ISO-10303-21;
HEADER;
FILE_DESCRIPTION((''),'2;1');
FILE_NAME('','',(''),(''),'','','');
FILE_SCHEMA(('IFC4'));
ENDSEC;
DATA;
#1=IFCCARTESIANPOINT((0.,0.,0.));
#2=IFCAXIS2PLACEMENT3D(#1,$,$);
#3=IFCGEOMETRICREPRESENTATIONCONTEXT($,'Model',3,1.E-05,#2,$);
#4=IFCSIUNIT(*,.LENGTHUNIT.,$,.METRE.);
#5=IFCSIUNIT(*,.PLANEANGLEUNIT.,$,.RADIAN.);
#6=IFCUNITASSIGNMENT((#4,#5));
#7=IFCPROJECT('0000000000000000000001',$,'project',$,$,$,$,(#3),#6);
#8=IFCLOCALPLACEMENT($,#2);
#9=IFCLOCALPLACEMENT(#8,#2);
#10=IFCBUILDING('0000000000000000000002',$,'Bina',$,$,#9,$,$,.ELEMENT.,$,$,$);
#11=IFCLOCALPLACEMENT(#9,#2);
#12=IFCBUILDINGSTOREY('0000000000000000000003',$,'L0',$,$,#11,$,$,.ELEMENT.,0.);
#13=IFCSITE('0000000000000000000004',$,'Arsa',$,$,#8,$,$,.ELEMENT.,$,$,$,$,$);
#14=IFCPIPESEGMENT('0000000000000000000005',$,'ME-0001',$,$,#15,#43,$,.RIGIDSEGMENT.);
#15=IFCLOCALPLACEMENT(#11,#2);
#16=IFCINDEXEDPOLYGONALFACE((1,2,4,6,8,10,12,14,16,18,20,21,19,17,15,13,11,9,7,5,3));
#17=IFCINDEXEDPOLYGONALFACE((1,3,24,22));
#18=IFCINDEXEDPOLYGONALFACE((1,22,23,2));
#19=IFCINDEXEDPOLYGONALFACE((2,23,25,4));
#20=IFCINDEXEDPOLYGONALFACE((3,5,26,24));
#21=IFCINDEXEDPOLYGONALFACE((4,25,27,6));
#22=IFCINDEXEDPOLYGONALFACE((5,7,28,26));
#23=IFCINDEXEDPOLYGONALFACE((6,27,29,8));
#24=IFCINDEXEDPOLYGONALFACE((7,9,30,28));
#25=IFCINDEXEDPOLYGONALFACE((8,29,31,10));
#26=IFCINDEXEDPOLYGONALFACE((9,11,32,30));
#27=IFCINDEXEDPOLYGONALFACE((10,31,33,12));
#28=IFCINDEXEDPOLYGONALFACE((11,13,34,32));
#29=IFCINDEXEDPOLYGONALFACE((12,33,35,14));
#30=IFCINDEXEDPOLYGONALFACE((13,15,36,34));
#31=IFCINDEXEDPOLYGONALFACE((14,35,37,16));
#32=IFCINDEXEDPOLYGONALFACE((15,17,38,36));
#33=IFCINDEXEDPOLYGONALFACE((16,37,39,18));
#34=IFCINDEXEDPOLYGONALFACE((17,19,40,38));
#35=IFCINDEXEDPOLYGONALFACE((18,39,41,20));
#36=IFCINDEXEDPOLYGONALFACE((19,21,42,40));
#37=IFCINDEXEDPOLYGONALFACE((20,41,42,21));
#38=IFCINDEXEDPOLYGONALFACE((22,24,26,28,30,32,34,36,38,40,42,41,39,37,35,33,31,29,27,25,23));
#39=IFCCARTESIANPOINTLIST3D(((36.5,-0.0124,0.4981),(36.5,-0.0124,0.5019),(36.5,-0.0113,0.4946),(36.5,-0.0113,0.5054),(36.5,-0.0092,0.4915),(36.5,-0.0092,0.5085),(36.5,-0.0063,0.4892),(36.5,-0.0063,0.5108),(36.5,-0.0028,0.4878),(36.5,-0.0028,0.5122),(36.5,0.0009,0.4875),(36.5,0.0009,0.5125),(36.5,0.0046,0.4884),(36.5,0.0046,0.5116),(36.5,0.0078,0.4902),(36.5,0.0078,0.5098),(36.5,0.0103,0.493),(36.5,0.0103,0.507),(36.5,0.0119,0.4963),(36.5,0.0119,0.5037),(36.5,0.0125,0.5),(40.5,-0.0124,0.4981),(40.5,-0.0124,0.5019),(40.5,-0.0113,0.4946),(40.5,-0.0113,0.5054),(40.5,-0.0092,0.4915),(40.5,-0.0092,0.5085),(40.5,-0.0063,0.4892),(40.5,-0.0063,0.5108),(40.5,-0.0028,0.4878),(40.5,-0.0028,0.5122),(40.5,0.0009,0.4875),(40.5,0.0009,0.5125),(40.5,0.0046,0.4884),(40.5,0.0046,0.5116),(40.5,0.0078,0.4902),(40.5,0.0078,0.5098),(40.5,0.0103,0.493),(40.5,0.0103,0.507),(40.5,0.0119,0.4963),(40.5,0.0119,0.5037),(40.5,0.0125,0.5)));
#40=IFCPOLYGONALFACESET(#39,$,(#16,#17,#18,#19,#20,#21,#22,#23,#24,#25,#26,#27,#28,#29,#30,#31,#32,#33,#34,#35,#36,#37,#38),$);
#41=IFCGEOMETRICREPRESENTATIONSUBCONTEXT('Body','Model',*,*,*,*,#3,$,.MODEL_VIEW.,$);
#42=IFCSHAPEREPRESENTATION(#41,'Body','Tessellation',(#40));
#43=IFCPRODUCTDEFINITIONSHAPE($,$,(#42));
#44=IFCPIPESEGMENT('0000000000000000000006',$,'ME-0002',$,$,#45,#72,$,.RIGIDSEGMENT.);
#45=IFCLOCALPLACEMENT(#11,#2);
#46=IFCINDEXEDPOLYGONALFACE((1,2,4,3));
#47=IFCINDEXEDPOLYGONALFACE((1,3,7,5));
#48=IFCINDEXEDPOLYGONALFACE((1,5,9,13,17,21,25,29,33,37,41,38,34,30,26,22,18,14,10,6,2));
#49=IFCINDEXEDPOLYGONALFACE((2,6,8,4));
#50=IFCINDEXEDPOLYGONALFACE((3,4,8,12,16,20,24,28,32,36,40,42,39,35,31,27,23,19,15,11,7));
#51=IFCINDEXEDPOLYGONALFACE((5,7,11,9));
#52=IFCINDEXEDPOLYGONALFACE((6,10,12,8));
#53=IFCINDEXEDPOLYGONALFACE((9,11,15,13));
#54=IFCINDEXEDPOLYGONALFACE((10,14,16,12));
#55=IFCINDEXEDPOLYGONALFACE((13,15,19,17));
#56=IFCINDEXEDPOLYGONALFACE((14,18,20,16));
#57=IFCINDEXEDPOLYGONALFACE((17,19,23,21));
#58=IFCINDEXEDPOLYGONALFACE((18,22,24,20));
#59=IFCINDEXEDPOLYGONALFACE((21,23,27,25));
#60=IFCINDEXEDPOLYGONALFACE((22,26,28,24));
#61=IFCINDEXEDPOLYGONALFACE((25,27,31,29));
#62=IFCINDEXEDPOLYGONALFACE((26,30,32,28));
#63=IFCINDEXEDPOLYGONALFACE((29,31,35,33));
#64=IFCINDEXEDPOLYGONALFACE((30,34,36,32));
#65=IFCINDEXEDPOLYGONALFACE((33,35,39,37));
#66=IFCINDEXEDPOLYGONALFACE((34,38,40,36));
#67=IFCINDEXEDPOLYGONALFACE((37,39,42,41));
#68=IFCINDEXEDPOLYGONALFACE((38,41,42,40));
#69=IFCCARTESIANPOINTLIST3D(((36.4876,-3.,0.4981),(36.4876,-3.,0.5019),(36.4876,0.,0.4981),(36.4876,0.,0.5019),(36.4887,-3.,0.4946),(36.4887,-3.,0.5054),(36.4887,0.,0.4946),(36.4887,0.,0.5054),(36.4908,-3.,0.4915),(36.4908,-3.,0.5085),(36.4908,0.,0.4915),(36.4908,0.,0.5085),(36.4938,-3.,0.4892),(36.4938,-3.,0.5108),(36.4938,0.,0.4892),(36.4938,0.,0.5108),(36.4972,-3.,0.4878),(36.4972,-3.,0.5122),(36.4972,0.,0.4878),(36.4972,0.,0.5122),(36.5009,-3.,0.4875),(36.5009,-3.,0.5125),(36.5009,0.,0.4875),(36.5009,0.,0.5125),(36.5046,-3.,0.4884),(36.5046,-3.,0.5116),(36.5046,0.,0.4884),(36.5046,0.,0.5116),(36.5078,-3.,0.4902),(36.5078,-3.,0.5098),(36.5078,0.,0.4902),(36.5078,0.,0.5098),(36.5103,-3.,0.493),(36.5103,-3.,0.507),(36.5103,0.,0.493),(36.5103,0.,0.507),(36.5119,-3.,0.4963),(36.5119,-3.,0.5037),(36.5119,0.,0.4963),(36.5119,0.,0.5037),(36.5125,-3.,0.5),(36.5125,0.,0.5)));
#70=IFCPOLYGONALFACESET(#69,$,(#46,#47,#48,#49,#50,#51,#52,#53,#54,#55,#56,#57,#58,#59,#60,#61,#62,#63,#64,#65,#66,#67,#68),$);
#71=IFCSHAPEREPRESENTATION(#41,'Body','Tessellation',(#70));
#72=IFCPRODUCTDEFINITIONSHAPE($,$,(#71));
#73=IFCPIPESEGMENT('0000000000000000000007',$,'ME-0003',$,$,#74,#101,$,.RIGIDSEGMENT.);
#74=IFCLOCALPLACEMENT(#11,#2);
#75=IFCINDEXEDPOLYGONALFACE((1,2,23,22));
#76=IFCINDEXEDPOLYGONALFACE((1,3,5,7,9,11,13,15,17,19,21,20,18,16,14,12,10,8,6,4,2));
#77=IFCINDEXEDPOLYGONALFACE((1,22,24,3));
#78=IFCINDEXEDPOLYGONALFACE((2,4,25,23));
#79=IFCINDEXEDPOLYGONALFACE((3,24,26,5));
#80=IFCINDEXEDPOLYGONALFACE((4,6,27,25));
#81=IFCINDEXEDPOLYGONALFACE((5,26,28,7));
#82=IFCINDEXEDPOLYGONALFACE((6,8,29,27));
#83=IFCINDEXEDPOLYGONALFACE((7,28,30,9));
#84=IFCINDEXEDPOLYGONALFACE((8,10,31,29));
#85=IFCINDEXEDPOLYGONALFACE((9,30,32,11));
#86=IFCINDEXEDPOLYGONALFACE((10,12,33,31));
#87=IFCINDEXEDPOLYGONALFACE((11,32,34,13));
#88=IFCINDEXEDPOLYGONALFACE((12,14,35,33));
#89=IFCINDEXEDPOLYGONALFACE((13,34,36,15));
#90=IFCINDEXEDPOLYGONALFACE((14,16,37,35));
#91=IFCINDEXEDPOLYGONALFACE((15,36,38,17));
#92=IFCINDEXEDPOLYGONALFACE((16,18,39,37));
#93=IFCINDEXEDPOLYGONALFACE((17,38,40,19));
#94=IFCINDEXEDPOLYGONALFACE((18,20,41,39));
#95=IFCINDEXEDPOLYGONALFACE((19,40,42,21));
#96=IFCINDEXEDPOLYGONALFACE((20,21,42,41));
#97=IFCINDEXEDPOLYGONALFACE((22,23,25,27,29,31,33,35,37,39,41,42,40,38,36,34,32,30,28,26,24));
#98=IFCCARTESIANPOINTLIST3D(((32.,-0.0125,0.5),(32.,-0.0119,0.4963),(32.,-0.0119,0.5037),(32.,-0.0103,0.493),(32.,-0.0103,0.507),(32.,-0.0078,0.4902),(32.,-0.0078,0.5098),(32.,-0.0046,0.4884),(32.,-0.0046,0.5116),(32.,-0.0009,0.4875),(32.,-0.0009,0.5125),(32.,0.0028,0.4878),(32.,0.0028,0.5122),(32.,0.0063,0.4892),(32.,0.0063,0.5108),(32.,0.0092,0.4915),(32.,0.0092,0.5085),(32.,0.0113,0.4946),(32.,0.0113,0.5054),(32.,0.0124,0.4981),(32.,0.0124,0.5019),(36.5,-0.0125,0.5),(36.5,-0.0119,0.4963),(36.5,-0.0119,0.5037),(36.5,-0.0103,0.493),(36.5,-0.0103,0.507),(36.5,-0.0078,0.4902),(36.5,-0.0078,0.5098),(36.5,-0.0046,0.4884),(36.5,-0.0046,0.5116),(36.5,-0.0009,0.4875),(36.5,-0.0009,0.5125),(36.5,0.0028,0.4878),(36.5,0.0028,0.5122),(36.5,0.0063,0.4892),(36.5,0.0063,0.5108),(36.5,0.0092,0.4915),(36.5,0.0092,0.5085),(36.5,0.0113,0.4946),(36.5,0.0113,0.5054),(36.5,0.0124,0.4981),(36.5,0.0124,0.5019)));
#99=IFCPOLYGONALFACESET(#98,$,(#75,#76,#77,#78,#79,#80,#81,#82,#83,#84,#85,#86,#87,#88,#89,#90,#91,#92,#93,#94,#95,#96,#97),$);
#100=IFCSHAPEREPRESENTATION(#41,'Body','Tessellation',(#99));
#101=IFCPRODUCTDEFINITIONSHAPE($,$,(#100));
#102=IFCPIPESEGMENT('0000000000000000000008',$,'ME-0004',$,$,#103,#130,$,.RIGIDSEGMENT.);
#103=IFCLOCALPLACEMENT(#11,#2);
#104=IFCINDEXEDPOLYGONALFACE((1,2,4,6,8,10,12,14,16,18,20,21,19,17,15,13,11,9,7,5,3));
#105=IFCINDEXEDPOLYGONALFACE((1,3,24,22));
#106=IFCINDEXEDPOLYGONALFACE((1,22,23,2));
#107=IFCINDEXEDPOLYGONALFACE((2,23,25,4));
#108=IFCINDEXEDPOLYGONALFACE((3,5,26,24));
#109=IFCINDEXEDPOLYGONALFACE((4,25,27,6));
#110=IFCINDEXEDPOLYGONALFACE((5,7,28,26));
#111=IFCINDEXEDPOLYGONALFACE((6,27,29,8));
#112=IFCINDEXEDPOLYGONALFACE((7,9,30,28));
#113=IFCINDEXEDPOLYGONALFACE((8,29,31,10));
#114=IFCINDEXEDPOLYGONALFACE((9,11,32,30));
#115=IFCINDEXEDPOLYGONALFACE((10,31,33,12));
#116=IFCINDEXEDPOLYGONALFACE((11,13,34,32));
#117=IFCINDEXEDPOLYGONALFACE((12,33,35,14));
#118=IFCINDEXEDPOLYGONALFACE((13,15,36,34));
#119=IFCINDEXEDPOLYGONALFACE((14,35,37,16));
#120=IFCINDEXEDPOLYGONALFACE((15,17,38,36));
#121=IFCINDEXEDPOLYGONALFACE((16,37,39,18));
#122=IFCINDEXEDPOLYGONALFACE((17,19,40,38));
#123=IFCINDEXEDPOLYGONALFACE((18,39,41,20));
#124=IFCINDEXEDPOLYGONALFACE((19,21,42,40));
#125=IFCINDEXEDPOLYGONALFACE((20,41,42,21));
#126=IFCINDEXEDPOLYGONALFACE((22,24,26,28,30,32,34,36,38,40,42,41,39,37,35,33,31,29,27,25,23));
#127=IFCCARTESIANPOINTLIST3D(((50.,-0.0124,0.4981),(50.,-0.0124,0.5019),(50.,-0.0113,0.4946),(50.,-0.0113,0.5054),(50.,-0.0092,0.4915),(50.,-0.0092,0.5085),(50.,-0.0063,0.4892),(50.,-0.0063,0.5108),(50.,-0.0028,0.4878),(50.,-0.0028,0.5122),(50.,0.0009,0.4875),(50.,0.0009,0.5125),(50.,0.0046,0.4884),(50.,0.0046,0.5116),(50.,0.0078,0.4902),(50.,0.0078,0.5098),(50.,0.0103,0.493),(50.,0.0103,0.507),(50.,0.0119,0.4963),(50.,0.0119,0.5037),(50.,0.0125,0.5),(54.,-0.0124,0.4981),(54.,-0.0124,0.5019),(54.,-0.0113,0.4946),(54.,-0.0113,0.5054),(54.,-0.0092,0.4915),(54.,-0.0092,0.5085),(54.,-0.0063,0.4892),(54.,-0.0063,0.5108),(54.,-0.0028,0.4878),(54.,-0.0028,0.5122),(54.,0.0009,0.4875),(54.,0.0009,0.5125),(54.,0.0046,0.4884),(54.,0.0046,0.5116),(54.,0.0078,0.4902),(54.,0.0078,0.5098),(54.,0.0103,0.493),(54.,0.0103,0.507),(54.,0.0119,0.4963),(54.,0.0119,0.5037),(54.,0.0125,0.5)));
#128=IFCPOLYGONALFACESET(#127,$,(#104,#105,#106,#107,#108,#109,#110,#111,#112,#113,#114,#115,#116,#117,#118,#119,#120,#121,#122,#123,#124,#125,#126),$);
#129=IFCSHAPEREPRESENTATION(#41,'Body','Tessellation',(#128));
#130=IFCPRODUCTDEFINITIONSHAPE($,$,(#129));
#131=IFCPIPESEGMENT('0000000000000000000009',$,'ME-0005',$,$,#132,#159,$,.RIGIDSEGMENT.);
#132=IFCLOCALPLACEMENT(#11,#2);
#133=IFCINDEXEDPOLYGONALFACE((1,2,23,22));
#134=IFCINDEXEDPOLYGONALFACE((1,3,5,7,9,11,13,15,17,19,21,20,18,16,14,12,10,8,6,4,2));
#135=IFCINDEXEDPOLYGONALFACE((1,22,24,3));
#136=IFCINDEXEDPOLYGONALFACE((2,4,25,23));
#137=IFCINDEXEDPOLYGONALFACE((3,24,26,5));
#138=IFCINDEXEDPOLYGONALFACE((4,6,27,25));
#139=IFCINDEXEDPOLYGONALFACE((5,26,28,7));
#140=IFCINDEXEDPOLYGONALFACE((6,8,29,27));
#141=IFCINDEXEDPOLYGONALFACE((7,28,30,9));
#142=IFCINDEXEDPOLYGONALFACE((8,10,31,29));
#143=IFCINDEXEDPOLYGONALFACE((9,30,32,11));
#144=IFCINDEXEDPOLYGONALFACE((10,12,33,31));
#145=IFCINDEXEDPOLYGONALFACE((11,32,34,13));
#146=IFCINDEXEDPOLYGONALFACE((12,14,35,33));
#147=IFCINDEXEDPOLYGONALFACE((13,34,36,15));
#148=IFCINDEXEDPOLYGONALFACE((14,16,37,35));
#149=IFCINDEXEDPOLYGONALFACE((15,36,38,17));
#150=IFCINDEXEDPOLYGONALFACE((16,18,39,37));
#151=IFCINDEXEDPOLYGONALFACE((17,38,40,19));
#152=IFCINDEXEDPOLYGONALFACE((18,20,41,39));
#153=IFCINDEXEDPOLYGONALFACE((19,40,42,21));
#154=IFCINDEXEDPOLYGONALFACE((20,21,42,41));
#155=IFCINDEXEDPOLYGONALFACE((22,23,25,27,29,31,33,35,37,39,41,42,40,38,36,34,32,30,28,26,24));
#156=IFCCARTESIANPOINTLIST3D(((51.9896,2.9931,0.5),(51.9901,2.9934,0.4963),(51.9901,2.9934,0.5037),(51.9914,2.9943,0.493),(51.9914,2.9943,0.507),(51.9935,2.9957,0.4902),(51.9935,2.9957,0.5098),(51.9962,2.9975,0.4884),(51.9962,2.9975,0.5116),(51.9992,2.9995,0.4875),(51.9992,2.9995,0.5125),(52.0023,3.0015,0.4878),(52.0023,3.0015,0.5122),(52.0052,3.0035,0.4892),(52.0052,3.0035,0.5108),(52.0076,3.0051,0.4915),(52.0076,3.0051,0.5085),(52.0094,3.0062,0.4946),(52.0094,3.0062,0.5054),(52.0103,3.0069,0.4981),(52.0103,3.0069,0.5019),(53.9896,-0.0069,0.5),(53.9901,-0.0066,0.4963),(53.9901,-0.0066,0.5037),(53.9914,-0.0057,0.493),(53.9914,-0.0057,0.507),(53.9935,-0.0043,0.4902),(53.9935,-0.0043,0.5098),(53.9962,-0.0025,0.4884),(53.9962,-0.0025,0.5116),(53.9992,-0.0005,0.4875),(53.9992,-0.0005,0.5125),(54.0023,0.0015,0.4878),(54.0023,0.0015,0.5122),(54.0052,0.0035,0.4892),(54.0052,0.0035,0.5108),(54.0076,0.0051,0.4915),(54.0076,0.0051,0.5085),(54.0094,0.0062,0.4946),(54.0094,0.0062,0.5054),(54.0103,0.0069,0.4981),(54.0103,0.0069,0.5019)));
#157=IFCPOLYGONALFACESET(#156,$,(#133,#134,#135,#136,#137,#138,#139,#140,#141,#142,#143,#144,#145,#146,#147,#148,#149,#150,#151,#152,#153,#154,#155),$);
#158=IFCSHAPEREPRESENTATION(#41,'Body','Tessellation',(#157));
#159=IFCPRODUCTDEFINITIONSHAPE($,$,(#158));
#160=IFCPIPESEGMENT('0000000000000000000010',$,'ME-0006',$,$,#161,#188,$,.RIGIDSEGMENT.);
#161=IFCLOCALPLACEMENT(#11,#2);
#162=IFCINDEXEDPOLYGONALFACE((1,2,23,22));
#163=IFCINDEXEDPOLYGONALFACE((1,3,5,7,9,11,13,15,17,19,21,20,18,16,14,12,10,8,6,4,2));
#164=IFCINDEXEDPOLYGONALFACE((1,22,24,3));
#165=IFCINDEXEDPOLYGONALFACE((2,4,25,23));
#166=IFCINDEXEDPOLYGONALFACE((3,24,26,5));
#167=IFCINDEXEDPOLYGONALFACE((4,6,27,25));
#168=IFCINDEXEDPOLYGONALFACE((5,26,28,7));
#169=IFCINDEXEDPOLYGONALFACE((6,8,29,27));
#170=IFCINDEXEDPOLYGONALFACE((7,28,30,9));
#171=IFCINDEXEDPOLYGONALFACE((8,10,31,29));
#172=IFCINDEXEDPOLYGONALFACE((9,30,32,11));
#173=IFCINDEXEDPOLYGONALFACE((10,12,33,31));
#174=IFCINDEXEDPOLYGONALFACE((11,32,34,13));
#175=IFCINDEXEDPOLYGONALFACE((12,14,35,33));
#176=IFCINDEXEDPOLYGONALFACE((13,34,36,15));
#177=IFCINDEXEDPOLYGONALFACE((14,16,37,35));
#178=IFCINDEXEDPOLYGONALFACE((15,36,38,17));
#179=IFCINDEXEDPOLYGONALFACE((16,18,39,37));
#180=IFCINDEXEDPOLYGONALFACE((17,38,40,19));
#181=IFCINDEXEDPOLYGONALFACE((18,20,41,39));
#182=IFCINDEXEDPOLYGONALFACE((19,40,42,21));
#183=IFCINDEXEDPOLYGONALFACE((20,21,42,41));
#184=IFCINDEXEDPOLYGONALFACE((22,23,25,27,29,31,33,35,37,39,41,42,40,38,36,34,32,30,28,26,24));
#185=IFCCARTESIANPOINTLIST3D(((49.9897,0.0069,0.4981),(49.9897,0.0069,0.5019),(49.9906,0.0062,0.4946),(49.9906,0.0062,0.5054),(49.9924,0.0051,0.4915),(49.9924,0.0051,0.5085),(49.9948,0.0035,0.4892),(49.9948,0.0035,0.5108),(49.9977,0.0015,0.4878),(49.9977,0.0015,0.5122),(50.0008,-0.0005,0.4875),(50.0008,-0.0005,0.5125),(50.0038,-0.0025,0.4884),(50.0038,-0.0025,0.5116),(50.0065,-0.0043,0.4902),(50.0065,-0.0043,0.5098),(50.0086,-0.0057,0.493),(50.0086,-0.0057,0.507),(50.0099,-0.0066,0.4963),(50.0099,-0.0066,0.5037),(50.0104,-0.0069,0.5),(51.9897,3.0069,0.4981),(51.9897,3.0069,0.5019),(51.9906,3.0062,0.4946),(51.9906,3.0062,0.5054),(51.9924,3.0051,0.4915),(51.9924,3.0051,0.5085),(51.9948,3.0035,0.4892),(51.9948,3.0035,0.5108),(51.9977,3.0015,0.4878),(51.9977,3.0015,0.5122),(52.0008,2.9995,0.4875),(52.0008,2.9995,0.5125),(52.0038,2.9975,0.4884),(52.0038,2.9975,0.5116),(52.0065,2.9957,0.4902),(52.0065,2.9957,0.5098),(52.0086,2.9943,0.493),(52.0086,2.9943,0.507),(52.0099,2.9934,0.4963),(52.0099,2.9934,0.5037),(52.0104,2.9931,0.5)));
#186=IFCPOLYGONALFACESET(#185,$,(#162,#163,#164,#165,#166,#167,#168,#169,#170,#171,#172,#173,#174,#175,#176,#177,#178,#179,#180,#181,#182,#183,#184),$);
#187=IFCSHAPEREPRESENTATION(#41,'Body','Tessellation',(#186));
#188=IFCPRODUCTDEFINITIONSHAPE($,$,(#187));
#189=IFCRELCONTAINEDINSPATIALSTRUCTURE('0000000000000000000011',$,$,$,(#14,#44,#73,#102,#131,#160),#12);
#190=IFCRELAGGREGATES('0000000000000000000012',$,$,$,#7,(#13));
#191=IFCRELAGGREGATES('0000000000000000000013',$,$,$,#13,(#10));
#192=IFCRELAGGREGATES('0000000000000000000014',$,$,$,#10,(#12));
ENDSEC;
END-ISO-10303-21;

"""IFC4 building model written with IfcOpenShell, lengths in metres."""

from ifc_helpers import new_model, si_unit, frame, origin, origin_2d, place, context, subcontext, project, spatial, circle, extrude, element, save


model = new_model("IFC4")

# Units and contexts
model_context = context("Model", 3, precision=1e-05, world=origin())
body_context = subcontext(model_context, "Body", "Model", "MODEL_VIEW")
ifc_project = project(units=[si_unit("LENGTHUNIT", "METRE"), si_unit("PLANEANGLEUNIT", "RADIAN")], contexts=[model_context])

# Site, building, storey
site_placement = place(None, origin())
site = spatial("IfcSite", under=ifc_project, at=site_placement, Name="Arsa", CompositionType="ELEMENT")
building_placement = place(site_placement, origin())
building = spatial("IfcBuilding", under=site, at=building_placement, Name="Bina", CompositionType="ELEMENT")
storey_placement = place(building_placement, origin())
storey = spatial("IfcBuildingStorey", under=building, at=storey_placement, Name="L0", CompositionType="ELEMENT", Elevation=0.0)

# Pipe segments
pipe_segment_1_placement = place(storey_placement, origin())
element("IfcPipeSegment", 1, at=pipe_segment_1_placement, inside=storey, Name="ME-0001", PredefinedType="RIGIDSEGMENT", context=body_context, shape_type="SweptSolid", body=[
    extrude(circle(Radius=0.0125, at=origin_2d()), frame((36.5, 0.0, 0.5), z_axis=(1.0, 0.0, 0.0), x_axis=(0.0, 1.0, 0.0)), (0.0, 0.0, 1.0), 4.0),
])
pipe_segment_2_placement = place(storey_placement, origin())
element("IfcPipeSegment", 2, at=pipe_segment_2_placement, inside=storey, Name="ME-0002", PredefinedType="RIGIDSEGMENT", context=body_context, shape_type="SweptSolid", body=[
    extrude(circle(Radius=0.0125, at=origin_2d()), frame((36.5, 0.0, 0.5), z_axis=(0.0, -1.0, 0.0), x_axis=(1.0, 0.0, 0.0)), (0.0, 0.0, 1.0), 3.0),
])
pipe_segment_3_placement = place(storey_placement, origin())
element("IfcPipeSegment", 3, at=pipe_segment_3_placement, inside=storey, Name="ME-0003", PredefinedType="RIGIDSEGMENT", context=body_context, shape_type="SweptSolid", body=[
    extrude(circle(Radius=0.0125, at=origin_2d()), frame((36.5, 0.0, 0.5), z_axis=(-1.0, 0.0, 0.0), x_axis=(0.0, -1.0, 0.0)), (0.0, 0.0, 1.0), 4.5),
])
pipe_segment_4_placement = place(storey_placement, origin())
element("IfcPipeSegment", 4, at=pipe_segment_4_placement, inside=storey, Name="ME-0004", PredefinedType="RIGIDSEGMENT", context=body_context, shape_type="SweptSolid", body=[
    extrude(circle(Radius=0.0125, at=origin_2d()), frame((50.0, 0.0, 0.5), z_axis=(1.0, 0.0, 0.0), x_axis=(0.0, 1.0, 0.0)), (0.0, 0.0, 1.0), 4.0),
])
pipe_segment_5_placement = place(storey_placement, origin())
element("IfcPipeSegment", 5, at=pipe_segment_5_placement, inside=storey, Name="ME-0005", PredefinedType="RIGIDSEGMENT", context=body_context, shape_type="SweptSolid", body=[
    extrude(circle(Radius=0.0125, at=origin_2d()), frame((54.0, 0.0, 0.5), z_axis=(-0.5547, 0.83205, 0.0), x_axis=(-0.83205, -0.5547, 0.0)), (0.0, 0.0, 1.0), 3.6056),
])
pipe_segment_6_placement = place(storey_placement, origin())
element("IfcPipeSegment", 6, at=pipe_segment_6_placement, inside=storey, Name="ME-0006", PredefinedType="RIGIDSEGMENT", context=body_context, shape_type="SweptSolid", body=[
    extrude(circle(Radius=0.0125, at=origin_2d()), frame((52.0, 3.0, 0.5), z_axis=(-0.5547, -0.83205, 0.0), x_axis=(0.83205, -0.5547, 0.0)), (0.0, 0.0, 1.0), 3.6056),
])

save(model, "model.ifc")
